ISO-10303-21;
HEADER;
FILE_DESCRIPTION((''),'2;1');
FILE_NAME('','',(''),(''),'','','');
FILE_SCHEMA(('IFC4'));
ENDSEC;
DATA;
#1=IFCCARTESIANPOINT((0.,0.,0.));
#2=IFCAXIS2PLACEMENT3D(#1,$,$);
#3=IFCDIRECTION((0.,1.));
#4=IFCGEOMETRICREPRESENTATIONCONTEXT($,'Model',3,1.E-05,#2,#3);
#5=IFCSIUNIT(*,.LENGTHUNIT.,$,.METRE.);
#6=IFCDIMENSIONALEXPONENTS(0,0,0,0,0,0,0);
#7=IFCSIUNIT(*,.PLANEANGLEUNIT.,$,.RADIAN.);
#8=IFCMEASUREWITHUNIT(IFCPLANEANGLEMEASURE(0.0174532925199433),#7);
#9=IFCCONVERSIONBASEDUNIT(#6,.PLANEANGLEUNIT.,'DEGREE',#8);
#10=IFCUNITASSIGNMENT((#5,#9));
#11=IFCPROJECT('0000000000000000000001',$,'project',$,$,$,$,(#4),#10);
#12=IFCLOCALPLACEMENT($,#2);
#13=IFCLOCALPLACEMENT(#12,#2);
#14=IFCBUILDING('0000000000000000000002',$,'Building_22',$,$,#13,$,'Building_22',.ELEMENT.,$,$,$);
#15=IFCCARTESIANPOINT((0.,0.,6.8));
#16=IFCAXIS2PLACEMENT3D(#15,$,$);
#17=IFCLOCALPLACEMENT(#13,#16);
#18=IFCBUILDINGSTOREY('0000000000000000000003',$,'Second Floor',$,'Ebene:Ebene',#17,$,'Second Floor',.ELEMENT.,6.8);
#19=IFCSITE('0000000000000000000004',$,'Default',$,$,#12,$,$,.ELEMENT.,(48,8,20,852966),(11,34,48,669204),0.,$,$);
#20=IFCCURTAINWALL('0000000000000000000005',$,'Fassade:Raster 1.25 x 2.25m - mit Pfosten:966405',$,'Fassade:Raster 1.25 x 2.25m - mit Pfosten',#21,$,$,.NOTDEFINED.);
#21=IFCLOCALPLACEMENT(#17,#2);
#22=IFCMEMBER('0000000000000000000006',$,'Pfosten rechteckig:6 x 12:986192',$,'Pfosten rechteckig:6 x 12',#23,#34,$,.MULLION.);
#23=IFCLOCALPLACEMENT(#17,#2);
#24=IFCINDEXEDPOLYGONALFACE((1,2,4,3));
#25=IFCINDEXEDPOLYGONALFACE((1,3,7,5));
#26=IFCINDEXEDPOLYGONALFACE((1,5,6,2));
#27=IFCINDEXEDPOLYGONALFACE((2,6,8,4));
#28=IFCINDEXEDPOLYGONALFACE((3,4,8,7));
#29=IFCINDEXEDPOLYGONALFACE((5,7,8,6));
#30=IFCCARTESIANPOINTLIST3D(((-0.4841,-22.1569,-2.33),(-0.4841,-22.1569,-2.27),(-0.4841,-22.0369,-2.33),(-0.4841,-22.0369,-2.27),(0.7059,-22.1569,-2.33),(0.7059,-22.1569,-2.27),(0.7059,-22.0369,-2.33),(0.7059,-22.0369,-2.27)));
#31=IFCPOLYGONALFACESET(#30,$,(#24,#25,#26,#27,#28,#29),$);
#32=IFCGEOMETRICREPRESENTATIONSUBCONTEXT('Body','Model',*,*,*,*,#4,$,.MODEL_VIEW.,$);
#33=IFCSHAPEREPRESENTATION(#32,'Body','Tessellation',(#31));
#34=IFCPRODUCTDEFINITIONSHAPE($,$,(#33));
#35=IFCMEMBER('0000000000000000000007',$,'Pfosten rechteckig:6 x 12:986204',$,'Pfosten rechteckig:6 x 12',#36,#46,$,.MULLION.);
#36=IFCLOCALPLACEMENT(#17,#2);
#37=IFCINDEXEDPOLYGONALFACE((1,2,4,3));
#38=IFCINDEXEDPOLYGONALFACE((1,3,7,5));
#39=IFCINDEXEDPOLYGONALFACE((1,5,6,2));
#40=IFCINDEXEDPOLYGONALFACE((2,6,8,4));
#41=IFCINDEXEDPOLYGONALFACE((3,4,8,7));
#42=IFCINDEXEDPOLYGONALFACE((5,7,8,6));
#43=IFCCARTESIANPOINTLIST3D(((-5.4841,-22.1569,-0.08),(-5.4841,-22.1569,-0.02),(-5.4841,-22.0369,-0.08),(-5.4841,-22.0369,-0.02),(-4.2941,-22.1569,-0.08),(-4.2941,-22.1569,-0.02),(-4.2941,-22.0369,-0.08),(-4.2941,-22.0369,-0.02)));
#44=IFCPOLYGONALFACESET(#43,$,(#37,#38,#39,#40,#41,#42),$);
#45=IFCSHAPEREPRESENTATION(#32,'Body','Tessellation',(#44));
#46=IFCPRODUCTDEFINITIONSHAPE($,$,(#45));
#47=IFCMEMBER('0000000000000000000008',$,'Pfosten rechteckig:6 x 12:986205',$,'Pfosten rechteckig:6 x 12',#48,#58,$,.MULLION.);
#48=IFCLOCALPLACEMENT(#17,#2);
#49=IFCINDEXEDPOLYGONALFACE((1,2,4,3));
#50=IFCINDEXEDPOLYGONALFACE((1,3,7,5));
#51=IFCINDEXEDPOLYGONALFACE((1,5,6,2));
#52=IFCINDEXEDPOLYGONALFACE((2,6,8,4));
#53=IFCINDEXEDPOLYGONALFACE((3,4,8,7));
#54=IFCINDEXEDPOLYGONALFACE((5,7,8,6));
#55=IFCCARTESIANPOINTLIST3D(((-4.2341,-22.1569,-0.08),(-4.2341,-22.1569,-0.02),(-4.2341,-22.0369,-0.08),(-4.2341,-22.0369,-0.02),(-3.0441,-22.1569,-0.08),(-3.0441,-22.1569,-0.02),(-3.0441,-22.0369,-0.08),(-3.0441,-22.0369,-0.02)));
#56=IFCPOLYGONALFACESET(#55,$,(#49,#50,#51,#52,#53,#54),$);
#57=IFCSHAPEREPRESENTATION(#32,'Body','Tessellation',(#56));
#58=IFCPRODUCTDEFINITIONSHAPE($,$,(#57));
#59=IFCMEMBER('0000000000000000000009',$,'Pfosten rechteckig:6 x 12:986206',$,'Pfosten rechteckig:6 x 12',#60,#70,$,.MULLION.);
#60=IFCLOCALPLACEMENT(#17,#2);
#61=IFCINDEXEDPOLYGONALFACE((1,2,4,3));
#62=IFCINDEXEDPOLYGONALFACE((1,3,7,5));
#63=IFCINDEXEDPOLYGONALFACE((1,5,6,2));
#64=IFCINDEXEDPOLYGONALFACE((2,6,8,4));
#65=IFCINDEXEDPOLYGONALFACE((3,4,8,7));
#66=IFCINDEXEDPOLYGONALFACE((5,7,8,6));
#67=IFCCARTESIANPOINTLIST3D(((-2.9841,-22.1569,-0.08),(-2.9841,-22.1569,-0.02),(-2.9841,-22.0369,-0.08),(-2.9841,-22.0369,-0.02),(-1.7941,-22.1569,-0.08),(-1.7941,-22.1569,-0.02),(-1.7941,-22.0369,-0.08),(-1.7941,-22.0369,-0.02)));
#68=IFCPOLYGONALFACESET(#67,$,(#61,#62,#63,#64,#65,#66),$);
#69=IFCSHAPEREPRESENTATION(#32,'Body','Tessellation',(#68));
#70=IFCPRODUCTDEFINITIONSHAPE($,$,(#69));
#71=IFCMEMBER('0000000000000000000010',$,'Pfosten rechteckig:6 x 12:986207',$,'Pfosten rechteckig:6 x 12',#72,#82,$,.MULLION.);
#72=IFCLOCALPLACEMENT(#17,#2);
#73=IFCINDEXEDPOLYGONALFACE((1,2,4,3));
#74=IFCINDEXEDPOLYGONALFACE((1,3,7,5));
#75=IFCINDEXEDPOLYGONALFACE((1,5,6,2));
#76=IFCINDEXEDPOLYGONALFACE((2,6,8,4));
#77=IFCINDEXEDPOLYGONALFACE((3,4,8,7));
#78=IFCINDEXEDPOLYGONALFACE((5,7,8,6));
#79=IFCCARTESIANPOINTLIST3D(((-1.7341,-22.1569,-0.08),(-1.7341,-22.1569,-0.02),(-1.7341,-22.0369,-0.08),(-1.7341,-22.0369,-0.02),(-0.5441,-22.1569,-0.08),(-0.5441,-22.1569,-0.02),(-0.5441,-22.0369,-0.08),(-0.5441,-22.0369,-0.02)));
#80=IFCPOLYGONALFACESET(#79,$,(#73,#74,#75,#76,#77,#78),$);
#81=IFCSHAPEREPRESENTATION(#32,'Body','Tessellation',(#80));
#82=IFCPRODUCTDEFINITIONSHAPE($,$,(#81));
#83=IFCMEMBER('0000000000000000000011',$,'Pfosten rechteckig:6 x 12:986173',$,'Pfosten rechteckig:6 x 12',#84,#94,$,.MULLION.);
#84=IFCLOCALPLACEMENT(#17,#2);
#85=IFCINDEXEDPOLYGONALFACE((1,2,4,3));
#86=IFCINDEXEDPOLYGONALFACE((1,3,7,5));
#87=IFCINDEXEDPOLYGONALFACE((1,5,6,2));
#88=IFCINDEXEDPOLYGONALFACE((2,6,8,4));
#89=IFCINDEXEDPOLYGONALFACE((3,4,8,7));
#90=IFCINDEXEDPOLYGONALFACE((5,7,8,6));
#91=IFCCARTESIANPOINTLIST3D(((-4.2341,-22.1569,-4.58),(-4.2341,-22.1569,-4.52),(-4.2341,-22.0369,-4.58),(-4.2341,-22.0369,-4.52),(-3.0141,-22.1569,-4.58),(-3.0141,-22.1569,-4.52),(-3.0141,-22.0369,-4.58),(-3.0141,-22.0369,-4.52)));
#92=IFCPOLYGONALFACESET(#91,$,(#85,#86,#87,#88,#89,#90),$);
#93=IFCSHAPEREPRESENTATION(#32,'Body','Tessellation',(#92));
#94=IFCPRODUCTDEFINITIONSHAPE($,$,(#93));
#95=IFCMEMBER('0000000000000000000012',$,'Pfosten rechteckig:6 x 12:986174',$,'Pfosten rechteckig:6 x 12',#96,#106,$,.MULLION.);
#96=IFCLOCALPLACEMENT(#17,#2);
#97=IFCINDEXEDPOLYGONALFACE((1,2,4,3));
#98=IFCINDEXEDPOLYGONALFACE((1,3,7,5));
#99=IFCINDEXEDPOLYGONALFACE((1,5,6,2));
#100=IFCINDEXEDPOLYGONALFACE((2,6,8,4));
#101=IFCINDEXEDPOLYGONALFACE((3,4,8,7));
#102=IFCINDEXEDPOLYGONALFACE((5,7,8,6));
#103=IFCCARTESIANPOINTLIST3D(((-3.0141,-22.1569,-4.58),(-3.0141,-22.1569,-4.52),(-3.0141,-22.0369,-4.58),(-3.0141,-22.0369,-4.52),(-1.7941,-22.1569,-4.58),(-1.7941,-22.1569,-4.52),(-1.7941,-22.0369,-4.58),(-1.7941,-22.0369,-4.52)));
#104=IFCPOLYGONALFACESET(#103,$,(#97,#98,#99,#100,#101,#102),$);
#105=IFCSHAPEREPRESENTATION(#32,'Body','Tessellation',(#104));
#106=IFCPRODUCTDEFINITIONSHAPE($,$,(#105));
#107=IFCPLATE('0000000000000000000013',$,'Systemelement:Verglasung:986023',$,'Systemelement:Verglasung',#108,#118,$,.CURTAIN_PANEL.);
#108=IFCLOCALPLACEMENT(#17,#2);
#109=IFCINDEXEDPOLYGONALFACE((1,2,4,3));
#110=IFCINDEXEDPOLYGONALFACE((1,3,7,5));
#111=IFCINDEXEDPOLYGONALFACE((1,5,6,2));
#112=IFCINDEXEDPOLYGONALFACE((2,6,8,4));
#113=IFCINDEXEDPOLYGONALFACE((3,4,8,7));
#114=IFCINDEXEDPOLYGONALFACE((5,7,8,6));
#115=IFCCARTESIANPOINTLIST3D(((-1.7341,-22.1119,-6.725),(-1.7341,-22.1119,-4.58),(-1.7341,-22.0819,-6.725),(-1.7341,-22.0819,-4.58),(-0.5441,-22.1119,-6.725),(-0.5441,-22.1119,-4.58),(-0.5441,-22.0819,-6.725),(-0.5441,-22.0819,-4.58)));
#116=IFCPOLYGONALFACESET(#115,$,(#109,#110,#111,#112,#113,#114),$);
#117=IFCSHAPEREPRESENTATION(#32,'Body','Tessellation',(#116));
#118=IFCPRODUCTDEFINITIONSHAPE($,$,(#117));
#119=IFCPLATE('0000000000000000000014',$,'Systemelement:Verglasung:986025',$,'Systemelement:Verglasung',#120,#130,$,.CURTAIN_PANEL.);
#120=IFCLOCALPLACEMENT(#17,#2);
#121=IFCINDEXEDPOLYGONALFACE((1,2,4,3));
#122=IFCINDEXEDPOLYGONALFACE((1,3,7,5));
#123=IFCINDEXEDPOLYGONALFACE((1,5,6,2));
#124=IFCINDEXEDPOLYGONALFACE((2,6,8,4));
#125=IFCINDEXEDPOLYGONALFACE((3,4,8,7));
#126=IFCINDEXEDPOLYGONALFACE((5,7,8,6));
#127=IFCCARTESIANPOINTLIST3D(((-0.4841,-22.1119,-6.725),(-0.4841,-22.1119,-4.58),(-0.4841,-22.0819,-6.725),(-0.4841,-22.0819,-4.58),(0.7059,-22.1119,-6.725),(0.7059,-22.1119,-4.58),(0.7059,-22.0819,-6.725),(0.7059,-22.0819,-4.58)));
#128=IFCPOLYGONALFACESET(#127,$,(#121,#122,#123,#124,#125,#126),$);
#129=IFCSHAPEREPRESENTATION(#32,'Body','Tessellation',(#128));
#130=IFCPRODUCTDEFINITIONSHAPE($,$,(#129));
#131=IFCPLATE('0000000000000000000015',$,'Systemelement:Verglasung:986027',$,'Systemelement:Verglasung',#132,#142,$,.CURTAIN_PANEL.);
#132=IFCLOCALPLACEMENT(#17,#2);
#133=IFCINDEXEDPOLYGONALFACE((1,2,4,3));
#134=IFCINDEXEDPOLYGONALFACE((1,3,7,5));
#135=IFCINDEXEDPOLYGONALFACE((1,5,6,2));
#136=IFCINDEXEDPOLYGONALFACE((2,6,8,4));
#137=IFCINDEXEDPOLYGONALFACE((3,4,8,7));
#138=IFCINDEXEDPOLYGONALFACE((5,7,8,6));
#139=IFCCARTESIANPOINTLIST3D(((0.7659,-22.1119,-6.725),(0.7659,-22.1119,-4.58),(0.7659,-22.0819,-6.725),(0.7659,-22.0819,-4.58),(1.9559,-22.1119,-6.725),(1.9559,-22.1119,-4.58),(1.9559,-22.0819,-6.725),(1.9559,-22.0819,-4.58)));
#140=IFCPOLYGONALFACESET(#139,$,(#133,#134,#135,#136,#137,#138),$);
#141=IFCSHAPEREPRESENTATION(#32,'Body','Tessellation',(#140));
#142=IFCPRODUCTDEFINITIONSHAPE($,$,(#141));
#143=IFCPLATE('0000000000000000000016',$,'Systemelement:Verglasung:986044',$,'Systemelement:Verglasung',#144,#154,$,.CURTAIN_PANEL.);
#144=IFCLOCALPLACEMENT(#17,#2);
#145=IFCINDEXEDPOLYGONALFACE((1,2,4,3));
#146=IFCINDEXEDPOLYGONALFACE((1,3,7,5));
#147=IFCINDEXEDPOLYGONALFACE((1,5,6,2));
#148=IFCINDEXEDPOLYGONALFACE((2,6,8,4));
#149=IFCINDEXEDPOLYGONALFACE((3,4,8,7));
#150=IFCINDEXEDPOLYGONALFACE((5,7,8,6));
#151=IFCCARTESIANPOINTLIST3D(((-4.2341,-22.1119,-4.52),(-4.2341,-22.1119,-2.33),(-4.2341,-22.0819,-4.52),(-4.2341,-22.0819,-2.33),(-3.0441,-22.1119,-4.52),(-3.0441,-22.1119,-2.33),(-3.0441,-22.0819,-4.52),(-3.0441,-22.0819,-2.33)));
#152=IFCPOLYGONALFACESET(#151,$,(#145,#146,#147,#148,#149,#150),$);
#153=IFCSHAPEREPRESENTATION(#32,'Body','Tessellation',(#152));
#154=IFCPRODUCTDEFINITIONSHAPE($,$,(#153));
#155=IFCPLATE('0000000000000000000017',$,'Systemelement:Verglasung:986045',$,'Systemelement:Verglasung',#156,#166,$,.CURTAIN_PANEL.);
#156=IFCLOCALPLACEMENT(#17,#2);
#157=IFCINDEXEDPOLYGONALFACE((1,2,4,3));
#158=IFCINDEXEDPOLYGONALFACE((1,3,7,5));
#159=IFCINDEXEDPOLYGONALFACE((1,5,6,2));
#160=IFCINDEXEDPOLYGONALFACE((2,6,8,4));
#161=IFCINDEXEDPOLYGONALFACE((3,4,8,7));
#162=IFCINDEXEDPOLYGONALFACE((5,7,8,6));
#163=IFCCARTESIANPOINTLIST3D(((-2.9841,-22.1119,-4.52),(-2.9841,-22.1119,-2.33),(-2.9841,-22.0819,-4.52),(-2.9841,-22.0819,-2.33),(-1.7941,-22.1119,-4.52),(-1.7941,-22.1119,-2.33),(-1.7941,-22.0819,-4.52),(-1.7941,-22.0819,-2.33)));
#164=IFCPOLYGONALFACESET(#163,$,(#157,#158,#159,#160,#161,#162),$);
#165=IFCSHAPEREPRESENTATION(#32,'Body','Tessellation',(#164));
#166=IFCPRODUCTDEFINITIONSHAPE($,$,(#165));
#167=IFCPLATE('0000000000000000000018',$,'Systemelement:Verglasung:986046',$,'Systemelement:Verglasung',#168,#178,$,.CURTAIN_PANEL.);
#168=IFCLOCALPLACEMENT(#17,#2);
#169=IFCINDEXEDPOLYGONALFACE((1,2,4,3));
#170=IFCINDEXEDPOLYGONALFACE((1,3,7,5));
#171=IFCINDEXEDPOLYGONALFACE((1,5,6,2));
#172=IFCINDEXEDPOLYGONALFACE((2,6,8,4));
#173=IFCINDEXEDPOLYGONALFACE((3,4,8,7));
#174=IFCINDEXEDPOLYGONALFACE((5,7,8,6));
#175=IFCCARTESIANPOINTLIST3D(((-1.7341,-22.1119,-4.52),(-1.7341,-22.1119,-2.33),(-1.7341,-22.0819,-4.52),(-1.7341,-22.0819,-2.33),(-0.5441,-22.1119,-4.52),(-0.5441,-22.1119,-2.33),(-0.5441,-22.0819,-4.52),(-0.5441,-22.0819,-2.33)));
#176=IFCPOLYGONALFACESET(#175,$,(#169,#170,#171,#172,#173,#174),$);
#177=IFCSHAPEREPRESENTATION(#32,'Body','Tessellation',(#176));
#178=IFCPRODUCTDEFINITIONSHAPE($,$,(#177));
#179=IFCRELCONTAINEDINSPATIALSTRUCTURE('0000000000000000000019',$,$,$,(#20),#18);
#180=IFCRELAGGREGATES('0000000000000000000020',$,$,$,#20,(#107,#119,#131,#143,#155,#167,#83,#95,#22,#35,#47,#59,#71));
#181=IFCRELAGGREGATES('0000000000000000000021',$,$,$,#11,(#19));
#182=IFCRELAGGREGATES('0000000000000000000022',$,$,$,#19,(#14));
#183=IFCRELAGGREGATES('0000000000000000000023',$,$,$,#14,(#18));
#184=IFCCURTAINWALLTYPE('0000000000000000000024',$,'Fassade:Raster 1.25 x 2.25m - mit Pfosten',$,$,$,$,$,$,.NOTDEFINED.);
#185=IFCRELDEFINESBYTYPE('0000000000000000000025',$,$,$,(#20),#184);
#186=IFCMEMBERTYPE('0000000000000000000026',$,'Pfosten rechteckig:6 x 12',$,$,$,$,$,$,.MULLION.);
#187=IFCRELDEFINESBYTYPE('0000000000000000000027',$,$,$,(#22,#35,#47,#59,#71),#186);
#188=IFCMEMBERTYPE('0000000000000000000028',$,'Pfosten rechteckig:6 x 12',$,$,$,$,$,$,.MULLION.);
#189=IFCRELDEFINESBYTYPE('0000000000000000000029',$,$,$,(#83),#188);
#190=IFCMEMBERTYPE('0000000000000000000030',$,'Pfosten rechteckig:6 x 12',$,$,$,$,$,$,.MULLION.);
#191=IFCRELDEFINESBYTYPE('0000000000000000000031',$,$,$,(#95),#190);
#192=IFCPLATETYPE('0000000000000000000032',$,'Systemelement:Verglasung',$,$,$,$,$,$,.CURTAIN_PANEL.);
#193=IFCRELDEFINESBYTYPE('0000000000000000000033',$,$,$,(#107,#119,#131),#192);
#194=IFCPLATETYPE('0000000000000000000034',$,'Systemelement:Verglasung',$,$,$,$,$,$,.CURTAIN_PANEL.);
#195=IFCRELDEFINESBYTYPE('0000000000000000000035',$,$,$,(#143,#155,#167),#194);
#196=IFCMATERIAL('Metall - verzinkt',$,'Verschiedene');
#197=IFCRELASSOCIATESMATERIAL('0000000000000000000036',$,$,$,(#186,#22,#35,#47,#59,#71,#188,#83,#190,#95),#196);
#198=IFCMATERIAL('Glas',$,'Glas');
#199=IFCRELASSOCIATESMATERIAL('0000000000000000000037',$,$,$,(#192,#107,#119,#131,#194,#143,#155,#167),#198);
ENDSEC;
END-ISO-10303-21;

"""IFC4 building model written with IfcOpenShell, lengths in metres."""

from ifc_helpers import new_model, entity, si_unit, converted_unit, direction, frame, origin, place, context, subcontext, project, spatial, indexed_curve, outline, extrude, source, transform, mapped, material, type_object, type_shapes, element, aggregate, save


model = new_model("IFC4")

# Units and contexts
model_context = context("Model", 3, precision=1e-05, world=origin(), true_north=direction((0.0, 1.0)))
body_context = subcontext(model_context, "Body", "Model", "MODEL_VIEW")
ifc_project = project(units=[si_unit("LENGTHUNIT", "METRE"), converted_unit("PLANEANGLEUNIT", "DEGREE", entity("IfcPlaneAngleMeasure", 0.0174532925199433), si_unit("PLANEANGLEUNIT", "RADIAN"), dimensions=[0, 0, 0, 0, 0, 0, 0])], contexts=[model_context])

# Site, building, storey
site_placement = place(None, origin())
site = spatial("IfcSite", under=ifc_project, at=site_placement, Name="Default", CompositionType="ELEMENT", RefLatitude=(48, 8, 20, 852966), RefLongitude=(11, 34, 48, 669204), RefElevation=0.0)
building_placement = place(site_placement, origin())
building = spatial("IfcBuilding", under=site, at=building_placement, Name="Building_22", LongName="Building_22", CompositionType="ELEMENT")
storey_placement = place(building_placement, frame((0.0, 0.0, 6.8)))
storey = spatial("IfcBuildingStorey", under=building, at=storey_placement, Name="Second Floor", ObjectType="Ebene:Ebene", LongName="Second Floor", CompositionType="ELEMENT", Elevation=6.8)

# Curtain wall, members, plates
curtain_wall_type = type_object("IfcCurtainWallType", Name="Fassade:Raster 1.25 x 2.25m - mit Pfosten", PredefinedType="NOTDEFINED")
curtain_wall_placement = place(storey_placement, frame((0.0, 0.0, -6.8)))
curtain_wall = element("IfcCurtainWall", 1, at=curtain_wall_placement, inside=storey, type_object=curtain_wall_type, Name="Fassade:Raster 1.25 x 2.25m - mit Pfosten:966405", ObjectType="Fassade:Raster 1.25 x 2.25m - mit Pfosten", PredefinedType="NOTDEFINED")
ifc_material_1 = material(Name="Metall - verzinkt", Category="Verschiedene")
member_type_1 = type_object("IfcMemberType", Name="Pfosten rechteckig:6 x 12", PredefinedType="MULLION", material=ifc_material_1)
shared_shape_1 = source(origin(), body_context, "Body", "SweptSolid", [
    extrude(outline(indexed_curve([(-0.03, -0.06), (0.03, -0.06), (0.03, 0.06), (-0.03, 0.06), (-0.03, -0.06)], self_intersect=False)), frame((0.0, 0.0, -1.19), z_axis=(0.0, 0.0, 1.0), x_axis=(-1.0, 0.0, 0.0)), (0.0, 0.0, 1.0), 1.19),
])
type_shapes(member_type_1, [shared_shape_1])
member_1_placement = place(curtain_wall_placement, frame((0.7059, -22.0969, 4.5), z_axis=(1.0, 0.0, 0.0), x_axis=(0.0, 0.0, 1.0)))
member_1 = element("IfcMember", 2, at=member_1_placement, type_object=member_type_1, material=ifc_material_1, Name="Pfosten rechteckig:6 x 12:986192", ObjectType="Pfosten rechteckig:6 x 12", PredefinedType="MULLION", context=body_context, shape_type="MappedRepresentation", body=[
    mapped(shared_shape_1, transform((0.0, 0.0, 0.0), scale=1.0)),
])
member_2_placement = place(curtain_wall_placement, frame((-4.2941, -22.0969, 6.75), z_axis=(1.0, 0.0, 0.0), x_axis=(0.0, 0.0, 1.0)))
member_2 = element("IfcMember", 3, at=member_2_placement, type_object=member_type_1, material=ifc_material_1, Name="Pfosten rechteckig:6 x 12:986204", ObjectType="Pfosten rechteckig:6 x 12", PredefinedType="MULLION", context=body_context, shape_type="MappedRepresentation", body=[
    mapped(shared_shape_1, transform((0.0, 0.0, 0.0), scale=1.0)),
])
member_3_placement = place(curtain_wall_placement, frame((-3.0441, -22.0969, 6.75), z_axis=(1.0, 0.0, 0.0), x_axis=(0.0, 0.0, 1.0)))
member_3 = element("IfcMember", 4, at=member_3_placement, type_object=member_type_1, material=ifc_material_1, Name="Pfosten rechteckig:6 x 12:986205", ObjectType="Pfosten rechteckig:6 x 12", PredefinedType="MULLION", context=body_context, shape_type="MappedRepresentation", body=[
    mapped(shared_shape_1, transform((0.0, 0.0, 0.0), scale=1.0)),
])
member_4_placement = place(curtain_wall_placement, frame((-1.7941, -22.0969, 6.75), z_axis=(1.0, 0.0, 0.0), x_axis=(0.0, 0.0, 1.0)))
member_4 = element("IfcMember", 5, at=member_4_placement, type_object=member_type_1, material=ifc_material_1, Name="Pfosten rechteckig:6 x 12:986206", ObjectType="Pfosten rechteckig:6 x 12", PredefinedType="MULLION", context=body_context, shape_type="MappedRepresentation", body=[
    mapped(shared_shape_1, transform((0.0, 0.0, 0.0), scale=1.0)),
])
member_5_placement = place(curtain_wall_placement, frame((-0.5441, -22.0969, 6.75), z_axis=(1.0, 0.0, 0.0), x_axis=(0.0, 0.0, 1.0)))
member_5 = element("IfcMember", 6, at=member_5_placement, type_object=member_type_1, material=ifc_material_1, Name="Pfosten rechteckig:6 x 12:986207", ObjectType="Pfosten rechteckig:6 x 12", PredefinedType="MULLION", context=body_context, shape_type="MappedRepresentation", body=[
    mapped(shared_shape_1, transform((0.0, 0.0, 0.0), scale=1.0)),
])
member_type_2 = type_object("IfcMemberType", Name="Pfosten rechteckig:6 x 12", PredefinedType="MULLION", material=ifc_material_1)
shared_shape_2 = source(origin(), body_context, "Body", "SweptSolid", [
    extrude(outline(indexed_curve([(-0.03, -0.06), (0.03, -0.06), (0.03, 0.06), (-0.03, 0.06), (-0.03, -0.06)], self_intersect=False)), frame((0.0, 0.0, -1.22), z_axis=(0.0, 0.0, 1.0), x_axis=(-1.0, 0.0, 0.0)), (0.0, 0.0, 1.0), 1.22),
])
type_shapes(member_type_2, [shared_shape_2])
member_6_placement = place(curtain_wall_placement, frame((-3.0141, -22.0969, 2.25), z_axis=(1.0, 0.0, 0.0), x_axis=(0.0, 0.0, 1.0)))
member_6 = element("IfcMember", 7, at=member_6_placement, type_object=member_type_2, material=ifc_material_1, Name="Pfosten rechteckig:6 x 12:986173", ObjectType="Pfosten rechteckig:6 x 12", PredefinedType="MULLION", context=body_context, shape_type="MappedRepresentation", body=[
    mapped(shared_shape_2, transform((0.0, 0.0, 0.0), scale=1.0)),
])
member_type_3 = type_object("IfcMemberType", Name="Pfosten rechteckig:6 x 12", PredefinedType="MULLION", material=ifc_material_1)
shared_shape_3 = source(origin(), body_context, "Body", "SweptSolid", [
    extrude(outline(indexed_curve([(-0.03, -0.06), (0.03, -0.06), (0.03, 0.06), (-0.03, 0.06), (-0.03, -0.06)], self_intersect=False)), frame((0.0, 0.0, -1.22), z_axis=(0.0, 0.0, 1.0), x_axis=(-1.0, 0.0, 0.0)), (0.0, 0.0, 1.0), 1.22),
])
type_shapes(member_type_3, [shared_shape_3])
member_7_placement = place(curtain_wall_placement, frame((-1.7941, -22.0969, 2.25), z_axis=(1.0, 0.0, 0.0), x_axis=(0.0, 0.0, 1.0)))
member_7 = element("IfcMember", 8, at=member_7_placement, type_object=member_type_3, material=ifc_material_1, Name="Pfosten rechteckig:6 x 12:986174", ObjectType="Pfosten rechteckig:6 x 12", PredefinedType="MULLION", context=body_context, shape_type="MappedRepresentation", body=[
    mapped(shared_shape_3, transform((0.0, 0.0, 0.0), scale=1.0)),
])
ifc_material_2 = material(Name="Glas", Category="Glas")
plate_type_1 = type_object("IfcPlateType", Name="Systemelement:Verglasung", PredefinedType="CURTAIN_PANEL", material=ifc_material_2)
shared_shape_4 = source(origin(), body_context, "Body", "SweptSolid", [
    extrude(outline(indexed_curve([(-0.015, -0.595), (0.015, -0.595), (0.015, 0.595), (-0.015, 0.595), (-0.015, -0.595)], self_intersect=False)), frame((0.0, 0.0, 0.0), z_axis=(0.0, 0.0, 1.0), x_axis=(0.0, 1.0, 0.0)), (0.0, 0.0, 1.0), 2.145),
])
type_shapes(plate_type_1, [shared_shape_4])
plate_1_placement = place(curtain_wall_placement, frame((-1.1391, -22.0969, 0.075)))
plate_1 = element("IfcPlate", 9, at=plate_1_placement, type_object=plate_type_1, material=ifc_material_2, Name="Systemelement:Verglasung:986023", ObjectType="Systemelement:Verglasung", PredefinedType="CURTAIN_PANEL", context=body_context, shape_type="MappedRepresentation", body=[
    mapped(shared_shape_4, transform((0.0, 0.0, 0.0), scale=1.0)),
])
plate_2_placement = place(curtain_wall_placement, frame((0.1109, -22.0969, 0.075)))
plate_2 = element("IfcPlate", 10, at=plate_2_placement, type_object=plate_type_1, material=ifc_material_2, Name="Systemelement:Verglasung:986025", ObjectType="Systemelement:Verglasung", PredefinedType="CURTAIN_PANEL", context=body_context, shape_type="MappedRepresentation", body=[
    mapped(shared_shape_4, transform((0.0, 0.0, 0.0), scale=1.0)),
])
plate_3_placement = place(curtain_wall_placement, frame((1.3609, -22.0969, 0.075)))
plate_3 = element("IfcPlate", 11, at=plate_3_placement, type_object=plate_type_1, material=ifc_material_2, Name="Systemelement:Verglasung:986027", ObjectType="Systemelement:Verglasung", PredefinedType="CURTAIN_PANEL", context=body_context, shape_type="MappedRepresentation", body=[
    mapped(shared_shape_4, transform((0.0, 0.0, 0.0), scale=1.0)),
])
plate_type_2 = type_object("IfcPlateType", Name="Systemelement:Verglasung", PredefinedType="CURTAIN_PANEL", material=ifc_material_2)
shared_shape_5 = source(origin(), body_context, "Body", "SweptSolid", [
    extrude(outline(indexed_curve([(-0.015, -0.595), (0.015, -0.595), (0.015, 0.595), (-0.015, 0.595), (-0.015, -0.595)], self_intersect=False)), frame((0.0, 0.0, 0.0), z_axis=(0.0, 0.0, 1.0), x_axis=(0.0, 1.0, 0.0)), (0.0, 0.0, 1.0), 2.19),
])
type_shapes(plate_type_2, [shared_shape_5])
plate_4_placement = place(curtain_wall_placement, frame((-3.6391, -22.0969, 2.28)))
plate_4 = element("IfcPlate", 12, at=plate_4_placement, type_object=plate_type_2, material=ifc_material_2, Name="Systemelement:Verglasung:986044", ObjectType="Systemelement:Verglasung", PredefinedType="CURTAIN_PANEL", context=body_context, shape_type="MappedRepresentation", body=[
    mapped(shared_shape_5, transform((0.0, 0.0, 0.0), scale=1.0)),
])
plate_5_placement = place(curtain_wall_placement, frame((-2.3891, -22.0969, 2.28)))
plate_5 = element("IfcPlate", 13, at=plate_5_placement, type_object=plate_type_2, material=ifc_material_2, Name="Systemelement:Verglasung:986045", ObjectType="Systemelement:Verglasung", PredefinedType="CURTAIN_PANEL", context=body_context, shape_type="MappedRepresentation", body=[
    mapped(shared_shape_5, transform((0.0, 0.0, 0.0), scale=1.0)),
])
plate_6_placement = place(curtain_wall_placement, frame((-1.1391, -22.0969, 2.28)))
plate_6 = element("IfcPlate", 14, at=plate_6_placement, type_object=plate_type_2, material=ifc_material_2, Name="Systemelement:Verglasung:986046", ObjectType="Systemelement:Verglasung", PredefinedType="CURTAIN_PANEL", context=body_context, shape_type="MappedRepresentation", body=[
    mapped(shared_shape_5, transform((0.0, 0.0, 0.0), scale=1.0)),
])
aggregate(curtain_wall, [plate_1, plate_2, plate_3, plate_4, plate_5, plate_6, member_6, member_7, member_1, member_2, member_3, member_4, member_5])

save(model, "model.ifc")
